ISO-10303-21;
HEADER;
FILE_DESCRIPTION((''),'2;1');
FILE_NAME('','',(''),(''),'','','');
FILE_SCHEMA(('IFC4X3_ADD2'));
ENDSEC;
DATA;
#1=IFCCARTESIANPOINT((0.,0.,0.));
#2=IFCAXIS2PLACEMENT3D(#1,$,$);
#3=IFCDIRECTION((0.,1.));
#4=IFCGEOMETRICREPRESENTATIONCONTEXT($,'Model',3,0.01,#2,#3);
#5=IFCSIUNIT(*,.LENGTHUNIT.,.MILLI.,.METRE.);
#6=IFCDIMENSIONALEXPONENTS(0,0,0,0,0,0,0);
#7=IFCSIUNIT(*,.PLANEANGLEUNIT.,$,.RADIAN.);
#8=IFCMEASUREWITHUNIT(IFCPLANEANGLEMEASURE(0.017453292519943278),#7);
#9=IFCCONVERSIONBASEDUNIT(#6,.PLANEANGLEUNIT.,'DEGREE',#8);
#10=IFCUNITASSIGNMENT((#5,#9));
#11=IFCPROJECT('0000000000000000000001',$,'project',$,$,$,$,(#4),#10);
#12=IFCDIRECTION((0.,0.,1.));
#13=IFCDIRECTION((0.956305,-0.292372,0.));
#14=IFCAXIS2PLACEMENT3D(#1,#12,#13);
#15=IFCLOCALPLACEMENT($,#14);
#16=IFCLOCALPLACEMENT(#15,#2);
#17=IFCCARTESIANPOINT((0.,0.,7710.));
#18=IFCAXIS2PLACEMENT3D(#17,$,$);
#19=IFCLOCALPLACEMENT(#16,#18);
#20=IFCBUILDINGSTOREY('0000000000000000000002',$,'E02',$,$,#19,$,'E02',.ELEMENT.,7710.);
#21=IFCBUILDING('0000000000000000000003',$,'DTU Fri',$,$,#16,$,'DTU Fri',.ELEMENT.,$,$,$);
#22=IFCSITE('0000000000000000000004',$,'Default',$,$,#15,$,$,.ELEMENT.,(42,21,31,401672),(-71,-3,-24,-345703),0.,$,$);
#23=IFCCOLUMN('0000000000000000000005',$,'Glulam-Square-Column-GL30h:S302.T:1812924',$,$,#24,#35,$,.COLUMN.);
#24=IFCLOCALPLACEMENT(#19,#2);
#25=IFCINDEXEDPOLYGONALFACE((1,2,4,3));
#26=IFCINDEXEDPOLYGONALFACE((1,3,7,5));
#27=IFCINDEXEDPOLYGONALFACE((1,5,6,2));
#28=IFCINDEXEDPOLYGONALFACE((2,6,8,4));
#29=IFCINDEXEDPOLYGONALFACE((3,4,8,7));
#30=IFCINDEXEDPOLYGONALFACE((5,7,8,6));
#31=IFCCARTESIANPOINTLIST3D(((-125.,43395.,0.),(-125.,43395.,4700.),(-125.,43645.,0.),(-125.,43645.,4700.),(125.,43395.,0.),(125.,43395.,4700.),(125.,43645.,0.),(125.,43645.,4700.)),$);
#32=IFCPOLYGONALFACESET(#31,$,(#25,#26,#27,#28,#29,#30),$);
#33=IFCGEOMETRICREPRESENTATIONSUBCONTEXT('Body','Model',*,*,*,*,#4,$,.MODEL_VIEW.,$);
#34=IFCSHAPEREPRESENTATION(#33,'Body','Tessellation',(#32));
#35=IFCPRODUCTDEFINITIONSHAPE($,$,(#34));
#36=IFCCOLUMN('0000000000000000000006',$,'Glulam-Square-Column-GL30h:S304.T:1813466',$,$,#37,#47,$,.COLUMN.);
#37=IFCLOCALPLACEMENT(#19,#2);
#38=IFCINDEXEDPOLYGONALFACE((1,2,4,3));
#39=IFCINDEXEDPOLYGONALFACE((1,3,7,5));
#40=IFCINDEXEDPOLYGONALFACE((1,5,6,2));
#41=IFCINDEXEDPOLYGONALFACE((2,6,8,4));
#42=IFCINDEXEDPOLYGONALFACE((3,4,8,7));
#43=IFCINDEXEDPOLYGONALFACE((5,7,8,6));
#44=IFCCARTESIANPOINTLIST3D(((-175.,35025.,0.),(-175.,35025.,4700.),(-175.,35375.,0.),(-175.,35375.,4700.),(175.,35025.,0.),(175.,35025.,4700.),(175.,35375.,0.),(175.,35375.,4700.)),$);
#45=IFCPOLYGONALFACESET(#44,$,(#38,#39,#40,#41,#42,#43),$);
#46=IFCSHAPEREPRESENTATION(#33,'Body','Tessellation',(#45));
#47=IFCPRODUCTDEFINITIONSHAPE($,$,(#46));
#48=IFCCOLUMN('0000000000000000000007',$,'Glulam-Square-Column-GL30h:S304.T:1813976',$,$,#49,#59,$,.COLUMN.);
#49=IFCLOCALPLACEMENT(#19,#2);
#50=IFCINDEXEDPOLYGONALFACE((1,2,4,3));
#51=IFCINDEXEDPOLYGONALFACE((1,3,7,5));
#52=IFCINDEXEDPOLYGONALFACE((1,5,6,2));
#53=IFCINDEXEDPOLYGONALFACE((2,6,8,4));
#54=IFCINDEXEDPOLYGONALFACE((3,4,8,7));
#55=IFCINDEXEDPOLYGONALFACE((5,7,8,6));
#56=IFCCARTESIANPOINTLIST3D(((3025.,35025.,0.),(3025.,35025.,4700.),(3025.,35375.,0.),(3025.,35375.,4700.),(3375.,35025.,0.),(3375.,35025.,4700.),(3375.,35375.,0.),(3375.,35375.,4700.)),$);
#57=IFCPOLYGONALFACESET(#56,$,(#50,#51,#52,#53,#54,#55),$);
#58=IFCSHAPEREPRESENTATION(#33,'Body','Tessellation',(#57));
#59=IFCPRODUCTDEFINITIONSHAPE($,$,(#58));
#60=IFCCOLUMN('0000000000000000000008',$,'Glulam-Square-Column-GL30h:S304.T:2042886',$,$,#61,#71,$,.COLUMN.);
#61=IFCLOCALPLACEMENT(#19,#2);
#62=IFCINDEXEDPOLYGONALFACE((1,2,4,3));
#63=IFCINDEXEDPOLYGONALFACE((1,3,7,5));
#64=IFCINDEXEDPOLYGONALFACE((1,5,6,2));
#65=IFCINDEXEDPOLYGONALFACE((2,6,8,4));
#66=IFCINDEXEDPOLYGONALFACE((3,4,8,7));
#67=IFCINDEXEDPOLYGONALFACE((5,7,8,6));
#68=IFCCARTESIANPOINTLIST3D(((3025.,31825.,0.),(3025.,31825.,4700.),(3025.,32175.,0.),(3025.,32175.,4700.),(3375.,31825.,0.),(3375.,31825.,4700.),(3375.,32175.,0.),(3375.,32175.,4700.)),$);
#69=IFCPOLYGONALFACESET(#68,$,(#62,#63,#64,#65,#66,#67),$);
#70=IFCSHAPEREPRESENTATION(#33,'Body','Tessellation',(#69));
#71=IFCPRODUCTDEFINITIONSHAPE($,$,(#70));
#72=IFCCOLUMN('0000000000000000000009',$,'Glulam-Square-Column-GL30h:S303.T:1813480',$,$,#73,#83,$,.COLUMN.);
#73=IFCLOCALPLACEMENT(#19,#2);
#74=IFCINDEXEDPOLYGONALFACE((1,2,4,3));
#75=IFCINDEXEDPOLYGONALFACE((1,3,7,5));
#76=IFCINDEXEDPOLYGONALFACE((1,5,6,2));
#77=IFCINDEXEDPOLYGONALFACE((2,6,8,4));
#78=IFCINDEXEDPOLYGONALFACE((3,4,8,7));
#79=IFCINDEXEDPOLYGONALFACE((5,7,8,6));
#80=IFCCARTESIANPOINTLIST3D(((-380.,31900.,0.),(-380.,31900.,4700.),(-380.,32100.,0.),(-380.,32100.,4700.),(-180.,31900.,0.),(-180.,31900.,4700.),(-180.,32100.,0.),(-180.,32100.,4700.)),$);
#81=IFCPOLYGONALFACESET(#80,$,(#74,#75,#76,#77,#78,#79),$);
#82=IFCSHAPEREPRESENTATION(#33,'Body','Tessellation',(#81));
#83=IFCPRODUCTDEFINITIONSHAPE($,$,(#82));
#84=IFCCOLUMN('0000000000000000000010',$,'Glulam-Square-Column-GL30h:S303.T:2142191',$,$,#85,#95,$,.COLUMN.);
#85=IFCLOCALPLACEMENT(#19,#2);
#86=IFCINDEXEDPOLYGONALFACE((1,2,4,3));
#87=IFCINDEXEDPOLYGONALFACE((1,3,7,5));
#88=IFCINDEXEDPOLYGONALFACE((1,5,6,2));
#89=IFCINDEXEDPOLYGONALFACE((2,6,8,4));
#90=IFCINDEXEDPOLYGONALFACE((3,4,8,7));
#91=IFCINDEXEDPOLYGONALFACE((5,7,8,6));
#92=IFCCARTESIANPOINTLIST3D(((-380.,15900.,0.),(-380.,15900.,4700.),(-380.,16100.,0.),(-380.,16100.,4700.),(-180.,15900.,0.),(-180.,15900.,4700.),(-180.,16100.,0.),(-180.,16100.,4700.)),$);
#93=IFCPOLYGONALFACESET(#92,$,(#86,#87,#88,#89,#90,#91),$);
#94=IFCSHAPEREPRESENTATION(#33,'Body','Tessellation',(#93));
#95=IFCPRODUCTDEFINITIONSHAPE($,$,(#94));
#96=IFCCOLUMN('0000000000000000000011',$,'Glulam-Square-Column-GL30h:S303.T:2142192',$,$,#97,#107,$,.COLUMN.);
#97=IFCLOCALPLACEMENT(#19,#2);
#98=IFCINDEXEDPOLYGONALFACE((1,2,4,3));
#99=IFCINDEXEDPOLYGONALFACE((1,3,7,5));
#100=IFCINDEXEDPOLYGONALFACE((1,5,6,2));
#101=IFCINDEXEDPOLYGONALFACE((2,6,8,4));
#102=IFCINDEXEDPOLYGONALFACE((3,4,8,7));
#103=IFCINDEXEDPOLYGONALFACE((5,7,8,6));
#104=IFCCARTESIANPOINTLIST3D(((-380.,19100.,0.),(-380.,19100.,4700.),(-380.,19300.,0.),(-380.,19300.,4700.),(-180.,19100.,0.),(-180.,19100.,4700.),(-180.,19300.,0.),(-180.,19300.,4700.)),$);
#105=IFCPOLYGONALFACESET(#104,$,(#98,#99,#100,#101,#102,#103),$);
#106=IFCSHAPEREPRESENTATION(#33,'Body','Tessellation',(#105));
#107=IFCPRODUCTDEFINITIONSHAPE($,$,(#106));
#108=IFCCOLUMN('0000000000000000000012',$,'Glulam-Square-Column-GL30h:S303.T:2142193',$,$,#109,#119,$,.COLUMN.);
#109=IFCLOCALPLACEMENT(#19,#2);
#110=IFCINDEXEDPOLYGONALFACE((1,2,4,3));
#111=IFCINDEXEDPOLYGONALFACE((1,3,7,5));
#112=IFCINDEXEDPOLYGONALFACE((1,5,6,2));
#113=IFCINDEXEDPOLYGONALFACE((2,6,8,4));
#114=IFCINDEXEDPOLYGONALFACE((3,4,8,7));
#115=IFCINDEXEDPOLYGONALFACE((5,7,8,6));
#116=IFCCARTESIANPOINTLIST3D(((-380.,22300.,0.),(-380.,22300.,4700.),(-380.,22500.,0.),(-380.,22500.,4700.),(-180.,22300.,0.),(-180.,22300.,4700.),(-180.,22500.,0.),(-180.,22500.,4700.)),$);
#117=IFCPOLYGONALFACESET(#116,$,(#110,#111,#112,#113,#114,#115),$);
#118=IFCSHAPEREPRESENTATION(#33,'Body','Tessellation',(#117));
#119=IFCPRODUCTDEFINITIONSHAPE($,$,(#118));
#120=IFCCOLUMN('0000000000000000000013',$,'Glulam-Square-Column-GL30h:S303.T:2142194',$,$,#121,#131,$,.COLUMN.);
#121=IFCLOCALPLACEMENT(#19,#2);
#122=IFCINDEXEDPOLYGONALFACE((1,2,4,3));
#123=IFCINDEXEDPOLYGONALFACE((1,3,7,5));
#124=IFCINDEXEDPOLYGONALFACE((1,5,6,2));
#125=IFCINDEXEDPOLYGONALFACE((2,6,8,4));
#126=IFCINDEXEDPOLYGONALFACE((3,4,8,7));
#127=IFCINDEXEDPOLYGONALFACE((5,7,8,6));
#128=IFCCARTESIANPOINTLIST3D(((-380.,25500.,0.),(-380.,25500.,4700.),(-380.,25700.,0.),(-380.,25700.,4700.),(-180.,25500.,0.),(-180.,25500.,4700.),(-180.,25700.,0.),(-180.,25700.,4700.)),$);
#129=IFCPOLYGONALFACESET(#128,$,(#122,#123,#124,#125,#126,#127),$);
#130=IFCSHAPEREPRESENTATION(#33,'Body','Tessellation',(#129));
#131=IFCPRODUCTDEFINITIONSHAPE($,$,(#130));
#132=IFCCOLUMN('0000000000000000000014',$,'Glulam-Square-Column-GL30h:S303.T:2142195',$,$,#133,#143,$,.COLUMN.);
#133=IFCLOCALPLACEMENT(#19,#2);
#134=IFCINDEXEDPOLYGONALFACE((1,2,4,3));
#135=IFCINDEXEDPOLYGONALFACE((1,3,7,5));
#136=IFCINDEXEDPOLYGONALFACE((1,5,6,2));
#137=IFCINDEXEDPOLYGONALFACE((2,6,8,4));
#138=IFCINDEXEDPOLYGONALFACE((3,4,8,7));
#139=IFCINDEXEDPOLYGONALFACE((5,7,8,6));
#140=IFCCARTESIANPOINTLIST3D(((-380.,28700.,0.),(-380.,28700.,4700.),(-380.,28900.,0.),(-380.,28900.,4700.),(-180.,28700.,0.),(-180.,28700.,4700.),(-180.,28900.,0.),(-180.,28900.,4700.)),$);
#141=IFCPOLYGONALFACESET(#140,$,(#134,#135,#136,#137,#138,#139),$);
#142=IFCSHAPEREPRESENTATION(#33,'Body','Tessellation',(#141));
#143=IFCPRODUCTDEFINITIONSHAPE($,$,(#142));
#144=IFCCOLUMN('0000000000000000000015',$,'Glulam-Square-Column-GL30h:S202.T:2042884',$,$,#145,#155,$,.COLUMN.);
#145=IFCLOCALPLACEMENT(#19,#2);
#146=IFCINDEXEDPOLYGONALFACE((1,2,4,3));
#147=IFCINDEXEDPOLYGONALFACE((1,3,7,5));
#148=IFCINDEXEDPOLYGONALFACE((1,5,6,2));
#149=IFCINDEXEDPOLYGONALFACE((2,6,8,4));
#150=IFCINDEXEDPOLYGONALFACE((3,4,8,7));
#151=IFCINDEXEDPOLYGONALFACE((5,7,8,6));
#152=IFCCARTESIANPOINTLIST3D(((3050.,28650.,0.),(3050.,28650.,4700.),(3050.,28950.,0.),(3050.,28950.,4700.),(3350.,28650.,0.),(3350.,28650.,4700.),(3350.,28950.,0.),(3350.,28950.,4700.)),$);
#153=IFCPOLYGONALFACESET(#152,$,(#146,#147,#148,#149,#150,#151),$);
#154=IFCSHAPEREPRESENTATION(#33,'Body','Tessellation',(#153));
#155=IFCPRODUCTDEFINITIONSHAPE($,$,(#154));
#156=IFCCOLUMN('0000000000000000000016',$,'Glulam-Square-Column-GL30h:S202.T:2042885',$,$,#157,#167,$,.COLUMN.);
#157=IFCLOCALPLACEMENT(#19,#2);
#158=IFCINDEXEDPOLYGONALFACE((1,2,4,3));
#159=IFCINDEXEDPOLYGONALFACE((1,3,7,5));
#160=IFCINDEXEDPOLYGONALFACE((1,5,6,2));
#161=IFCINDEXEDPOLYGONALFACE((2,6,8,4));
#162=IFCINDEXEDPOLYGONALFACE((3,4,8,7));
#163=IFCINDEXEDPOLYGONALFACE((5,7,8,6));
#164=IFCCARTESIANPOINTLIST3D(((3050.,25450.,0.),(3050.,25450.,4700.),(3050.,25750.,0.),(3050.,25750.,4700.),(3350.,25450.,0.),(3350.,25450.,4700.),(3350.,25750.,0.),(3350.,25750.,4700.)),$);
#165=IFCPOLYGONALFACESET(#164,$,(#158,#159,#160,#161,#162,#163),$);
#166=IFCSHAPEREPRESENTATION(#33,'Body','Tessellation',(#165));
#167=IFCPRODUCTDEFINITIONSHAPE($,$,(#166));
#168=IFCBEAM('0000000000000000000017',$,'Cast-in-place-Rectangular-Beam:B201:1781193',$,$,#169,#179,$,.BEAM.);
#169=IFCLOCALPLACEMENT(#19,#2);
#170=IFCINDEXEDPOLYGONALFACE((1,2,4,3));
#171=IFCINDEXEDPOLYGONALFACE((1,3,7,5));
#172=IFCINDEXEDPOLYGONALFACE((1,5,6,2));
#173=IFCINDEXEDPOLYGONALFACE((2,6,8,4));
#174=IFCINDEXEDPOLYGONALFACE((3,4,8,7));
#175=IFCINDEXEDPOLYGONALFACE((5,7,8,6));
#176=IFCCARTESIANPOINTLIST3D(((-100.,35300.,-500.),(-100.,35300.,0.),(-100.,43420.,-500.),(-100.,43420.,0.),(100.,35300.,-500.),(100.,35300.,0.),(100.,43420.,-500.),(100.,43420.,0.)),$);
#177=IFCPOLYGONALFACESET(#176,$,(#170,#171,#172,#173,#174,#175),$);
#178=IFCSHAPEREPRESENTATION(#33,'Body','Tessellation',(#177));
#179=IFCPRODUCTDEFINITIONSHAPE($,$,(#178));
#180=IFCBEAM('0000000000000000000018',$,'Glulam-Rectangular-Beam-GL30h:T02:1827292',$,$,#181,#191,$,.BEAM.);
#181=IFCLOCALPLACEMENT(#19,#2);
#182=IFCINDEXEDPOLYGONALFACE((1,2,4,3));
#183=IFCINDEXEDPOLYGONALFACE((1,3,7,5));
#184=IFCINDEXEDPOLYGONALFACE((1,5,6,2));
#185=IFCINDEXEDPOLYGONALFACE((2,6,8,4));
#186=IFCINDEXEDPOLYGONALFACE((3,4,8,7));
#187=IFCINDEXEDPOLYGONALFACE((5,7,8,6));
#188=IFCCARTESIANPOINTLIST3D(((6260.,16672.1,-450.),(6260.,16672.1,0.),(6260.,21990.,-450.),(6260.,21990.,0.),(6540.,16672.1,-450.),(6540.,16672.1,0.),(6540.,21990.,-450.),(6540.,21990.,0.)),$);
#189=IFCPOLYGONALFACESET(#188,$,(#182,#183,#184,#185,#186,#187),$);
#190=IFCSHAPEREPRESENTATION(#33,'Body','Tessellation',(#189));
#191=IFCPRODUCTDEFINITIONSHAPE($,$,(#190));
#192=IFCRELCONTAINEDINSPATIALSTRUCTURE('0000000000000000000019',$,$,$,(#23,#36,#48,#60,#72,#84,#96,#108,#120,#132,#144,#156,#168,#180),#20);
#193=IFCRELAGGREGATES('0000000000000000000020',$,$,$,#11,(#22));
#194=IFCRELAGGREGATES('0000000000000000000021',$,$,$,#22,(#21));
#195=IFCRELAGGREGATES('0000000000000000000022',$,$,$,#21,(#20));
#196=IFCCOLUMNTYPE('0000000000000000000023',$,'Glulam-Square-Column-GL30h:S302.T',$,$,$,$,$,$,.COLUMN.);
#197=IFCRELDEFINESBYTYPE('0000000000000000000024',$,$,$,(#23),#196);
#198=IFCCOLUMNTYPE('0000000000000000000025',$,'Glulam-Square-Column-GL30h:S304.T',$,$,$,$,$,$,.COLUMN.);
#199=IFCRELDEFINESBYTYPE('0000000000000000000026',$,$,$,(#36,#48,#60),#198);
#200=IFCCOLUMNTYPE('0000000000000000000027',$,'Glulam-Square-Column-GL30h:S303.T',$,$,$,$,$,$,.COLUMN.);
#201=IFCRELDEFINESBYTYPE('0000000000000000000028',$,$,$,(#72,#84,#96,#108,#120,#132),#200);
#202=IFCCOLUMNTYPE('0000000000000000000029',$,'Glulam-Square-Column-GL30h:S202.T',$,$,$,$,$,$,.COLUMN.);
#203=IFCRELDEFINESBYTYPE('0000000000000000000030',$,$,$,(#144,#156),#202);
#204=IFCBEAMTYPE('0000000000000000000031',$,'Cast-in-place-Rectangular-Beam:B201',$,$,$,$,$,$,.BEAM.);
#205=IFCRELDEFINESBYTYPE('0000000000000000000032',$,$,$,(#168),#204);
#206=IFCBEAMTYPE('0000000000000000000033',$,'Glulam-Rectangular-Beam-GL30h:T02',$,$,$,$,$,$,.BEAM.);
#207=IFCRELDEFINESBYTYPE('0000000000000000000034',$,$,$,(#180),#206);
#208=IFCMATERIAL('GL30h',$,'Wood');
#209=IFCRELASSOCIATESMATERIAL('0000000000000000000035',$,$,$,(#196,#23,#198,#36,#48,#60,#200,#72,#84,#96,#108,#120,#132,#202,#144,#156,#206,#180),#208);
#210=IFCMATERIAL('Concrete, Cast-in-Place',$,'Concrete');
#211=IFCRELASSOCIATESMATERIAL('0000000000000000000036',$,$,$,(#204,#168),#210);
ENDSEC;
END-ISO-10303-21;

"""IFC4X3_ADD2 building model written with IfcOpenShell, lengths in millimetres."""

from ifc_helpers import new_model, entity, si_unit, converted_unit, direction, frame, origin, origin_2d_with_axis, place, context, subcontext, project, spatial, rectangle, extrude, source, transform, mapped, material, material_profile, profile_set, profile_usage, type_object, type_shapes, element, save


model = new_model("IFC4X3_ADD2")

# Units and contexts
model_context = context("Model", 3, precision=0.01, world=origin(), true_north=direction((0.0, 1.0)))
body_context = subcontext(model_context, "Body", "Model", "MODEL_VIEW")
ifc_project = project(units=[si_unit("LENGTHUNIT", "METRE", prefix="MILLI"), converted_unit("PLANEANGLEUNIT", "DEGREE", entity("IfcPlaneAngleMeasure", 0.017453292519943278), si_unit("PLANEANGLEUNIT", "RADIAN"), dimensions=[0, 0, 0, 0, 0, 0, 0])], contexts=[model_context])

# Site, building, storey
site_placement = place(None, frame((0.0, 0.0, 0.0), z_axis=(0.0, 0.0, 1.0), x_axis=(0.956305, -0.292372, 0.0)))
site = spatial("IfcSite", under=ifc_project, at=site_placement, Name="Default", CompositionType="ELEMENT", RefLatitude=(42, 21, 31, 401672), RefLongitude=(-71, -3, -24, -345703), RefElevation=0.0)
building_placement = place(site_placement, origin())
building = spatial("IfcBuilding", under=site, at=building_placement, Name="DTU Fri", LongName="DTU Fri", CompositionType="ELEMENT")
storey_placement = place(building_placement, frame((0.0, 0.0, 7710.0)))
storey = spatial("IfcBuildingStorey", under=building, at=storey_placement, Name="E02", LongName="E02", CompositionType="ELEMENT", Elevation=7710.0)

# Columns
ifc_material_1 = material(Name="GL30h", Category="Wood")
ifc_material_profile_1 = material_profile(ifc_material_1, rectangle(XDim=250.0, YDim=250.0, at=origin_2d_with_axis()), Name="S302.T")
ifc_profile_set_1 = profile_set([ifc_material_profile_1], Name="S302.T")
ifc_profile_usage_1 = profile_usage(ifc_profile_set_1)
column_type_1 = type_object("IfcColumnType", Name="Glulam-Square-Column-GL30h:S302.T", PredefinedType="COLUMN", material=ifc_profile_set_1)
shared_shape_1 = source(origin(), body_context, "Body", "SweptSolid", [
    extrude(rectangle(XDim=250.0, YDim=250.0, at=origin_2d_with_axis()), frame((0.0, 0.0, 7710.0), z_axis=(0.0, 0.0, 1.0), x_axis=(0.0, 1.0, 0.0)), (0.0, 0.0, 1.0), 4700.0),
])
type_shapes(column_type_1, [shared_shape_1])
column_placement = place(storey_placement, frame((0.0, 43520.0, -7710.0)))
element("IfcColumn", 1, at=column_placement, inside=storey, type_object=column_type_1, material=ifc_profile_usage_1, Name="Glulam-Square-Column-GL30h:S302.T:1812924", PredefinedType="COLUMN", context=body_context, shape_type="MappedRepresentation", body=[
    mapped(shared_shape_1, transform((0.0, 0.0, 0.0), scale=1.0)),
])
ifc_material_profile_2 = material_profile(ifc_material_1, rectangle(XDim=350.0, YDim=350.0, at=origin_2d_with_axis()), Name="S304.T")
ifc_profile_set_2 = profile_set([ifc_material_profile_2], Name="S304.T")
ifc_profile_usage_2 = profile_usage(ifc_profile_set_2)
column_type_2 = type_object("IfcColumnType", Name="Glulam-Square-Column-GL30h:S304.T", PredefinedType="COLUMN", material=ifc_profile_set_2)
shared_shape_2 = source(origin(), body_context, "Body", "SweptSolid", [
    extrude(rectangle(XDim=350.0, YDim=350.0, at=origin_2d_with_axis()), frame((0.0, 0.0, 7710.0), z_axis=(0.0, 0.0, 1.0), x_axis=(0.0, 1.0, 0.0)), (0.0, 0.0, 1.0), 4700.0),
])
type_shapes(column_type_2, [shared_shape_2])
for number, where, name in (
    (2, (0.0, 35200.0, -7710.0), "Glulam-Square-Column-GL30h:S304.T:1813466"),
    (3, (3200.0, 35200.0, -7710.0), "Glulam-Square-Column-GL30h:S304.T:1813976"),
    (4, (3200.0, 32000.0, -7710.0), "Glulam-Square-Column-GL30h:S304.T:2042886"),
):
    element("IfcColumn", number, at=place(storey_placement, frame(where)), inside=storey, type_object=column_type_2, material=ifc_profile_usage_2, Name=name, PredefinedType="COLUMN", context=body_context, shape_type="MappedRepresentation", body=[
        mapped(shared_shape_2, transform((0.0, 0.0, 0.0), scale=1.0)),
    ])
ifc_material_profile_3 = material_profile(ifc_material_1, rectangle(XDim=200.0, YDim=200.0, at=origin_2d_with_axis()), Name="S303.T")
ifc_profile_set_3 = profile_set([ifc_material_profile_3], Name="S303.T")
ifc_profile_usage_3 = profile_usage(ifc_profile_set_3)
column_type_3 = type_object("IfcColumnType", Name="Glulam-Square-Column-GL30h:S303.T", PredefinedType="COLUMN", material=ifc_profile_set_3)
shared_shape_3 = source(origin(), body_context, "Body", "SweptSolid", [
    extrude(rectangle(XDim=200.0, YDim=200.0, at=origin_2d_with_axis()), frame((0.0, 0.0, 7710.0), z_axis=(0.0, 0.0, 1.0), x_axis=(0.0, 1.0, 0.0)), (0.0, 0.0, 1.0), 4700.0),
])
type_shapes(column_type_3, [shared_shape_3])
for number, where, name in (
    (5, (-280.0, 32000.0, -7710.0), "Glulam-Square-Column-GL30h:S303.T:1813480"),
    (6, (-280.0, 16000.0, -7710.0), "Glulam-Square-Column-GL30h:S303.T:2142191"),
    (7, (-280.0, 19200.0, -7710.0), "Glulam-Square-Column-GL30h:S303.T:2142192"),
    (8, (-280.0, 22400.0, -7710.0), "Glulam-Square-Column-GL30h:S303.T:2142193"),
    (9, (-280.0, 25600.0, -7710.0), "Glulam-Square-Column-GL30h:S303.T:2142194"),
    (10, (-280.0, 28800.0, -7710.0), "Glulam-Square-Column-GL30h:S303.T:2142195"),
):
    element("IfcColumn", number, at=place(storey_placement, frame(where)), inside=storey, type_object=column_type_3, material=ifc_profile_usage_3, Name=name, PredefinedType="COLUMN", context=body_context, shape_type="MappedRepresentation", body=[
        mapped(shared_shape_3, transform((0.0, 0.0, 0.0), scale=1.0)),
    ])
ifc_material_profile_4 = material_profile(ifc_material_1, rectangle(XDim=300.0, YDim=300.0, at=origin_2d_with_axis()), Name="S202.T")
ifc_profile_set_4 = profile_set([ifc_material_profile_4], Name="S202.T")
ifc_profile_usage_4 = profile_usage(ifc_profile_set_4)
column_type_4 = type_object("IfcColumnType", Name="Glulam-Square-Column-GL30h:S202.T", PredefinedType="COLUMN", material=ifc_profile_set_4)
shared_shape_4 = source(origin(), body_context, "Body", "SweptSolid", [
    extrude(rectangle(XDim=300.0, YDim=300.0, at=origin_2d_with_axis()), frame((0.0, 0.0, 7710.0), z_axis=(0.0, 0.0, 1.0), x_axis=(0.0, 1.0, 0.0)), (0.0, 0.0, 1.0), 4700.0),
])
type_shapes(column_type_4, [shared_shape_4])
for number, where, name in (
    (11, (3200.0, 28800.0, -7710.0), "Glulam-Square-Column-GL30h:S202.T:2042884"),
    (12, (3200.0, 25600.0, -7710.0), "Glulam-Square-Column-GL30h:S202.T:2042885"),
):
    element("IfcColumn", number, at=place(storey_placement, frame(where)), inside=storey, type_object=column_type_4, material=ifc_profile_usage_4, Name=name, PredefinedType="COLUMN", context=body_context, shape_type="MappedRepresentation", body=[
        mapped(shared_shape_4, transform((0.0, 0.0, 0.0), scale=1.0)),
    ])

# Beams
ifc_material_2 = material(Name="Concrete, Cast-in-Place", Category="Concrete")
ifc_material_profile_5 = material_profile(ifc_material_2, rectangle(XDim=500.0, YDim=200.0, at=origin_2d_with_axis()), Name="B201")
ifc_profile_set_5 = profile_set([ifc_material_profile_5], Name="B201")
ifc_profile_usage_5 = profile_usage(ifc_profile_set_5, cardinal=8)
beam_type_1 = type_object("IfcBeamType", Name="Cast-in-place-Rectangular-Beam:B201", PredefinedType="BEAM", material=ifc_profile_set_5)
shared_shape_5 = source(origin(), body_context, "Body", "SweptSolid", [
    extrude(rectangle(XDim=500.0, YDim=200.0, at=origin_2d_with_axis()), frame((-4070.0, 0.0, 0.0), z_axis=(1.0, 0.0, 0.0), x_axis=(0.0, 0.0, -1.0)), (0.0, 0.0, 1.0), 8120.0),
])
type_shapes(beam_type_1, [shared_shape_5])
beam_1_placement = place(storey_placement, frame((0.0, 39350.0, -250.0), z_axis=(0.0, 0.0, 1.0), x_axis=(0.0, -1.0, 0.0)))
element("IfcBeam", 13, at=beam_1_placement, inside=storey, type_object=beam_type_1, material=ifc_profile_usage_5, Name="Cast-in-place-Rectangular-Beam:B201:1781193", PredefinedType="BEAM", context=body_context, shape_type="MappedRepresentation", body=[
    mapped(shared_shape_5, transform((0.0, 0.0, 0.0), scale=1.0)),
])
ifc_material_profile_6 = material_profile(ifc_material_1, rectangle(XDim=450.0, YDim=280.0, at=origin_2d_with_axis()), Name="T02")
ifc_profile_set_6 = profile_set([ifc_material_profile_6], Name="T02")
ifc_profile_usage_6 = profile_usage(ifc_profile_set_6, cardinal=8)
beam_type_2 = type_object("IfcBeamType", Name="Glulam-Rectangular-Beam-GL30h:T02", PredefinedType="BEAM", material=ifc_profile_set_6)
shared_shape_6 = source(origin(), body_context, "Body", "SweptSolid", [
    extrude(rectangle(XDim=450.0, YDim=280.0, at=origin_2d_with_axis()), frame((-2684.0, 0.0, 0.0), z_axis=(1.0, 0.0, 0.0), x_axis=(0.0, 0.0, -1.0)), (0.0, 0.0, 1.0), 5317.9),
])
type_shapes(beam_type_2, [shared_shape_6])
beam_2_placement = place(storey_placement, frame((6400.0, 19356.0, -225.0), z_axis=(0.0, 0.0, 1.0), x_axis=(0.0, 1.0, 0.0)))
element("IfcBeam", 14, at=beam_2_placement, inside=storey, type_object=beam_type_2, material=ifc_profile_usage_6, Name="Glulam-Rectangular-Beam-GL30h:T02:1827292", PredefinedType="BEAM", context=body_context, shape_type="MappedRepresentation", body=[
    mapped(shared_shape_6, transform((0.0, 0.0, 0.0), scale=1.0)),
])

save(model, "model.ifc")
